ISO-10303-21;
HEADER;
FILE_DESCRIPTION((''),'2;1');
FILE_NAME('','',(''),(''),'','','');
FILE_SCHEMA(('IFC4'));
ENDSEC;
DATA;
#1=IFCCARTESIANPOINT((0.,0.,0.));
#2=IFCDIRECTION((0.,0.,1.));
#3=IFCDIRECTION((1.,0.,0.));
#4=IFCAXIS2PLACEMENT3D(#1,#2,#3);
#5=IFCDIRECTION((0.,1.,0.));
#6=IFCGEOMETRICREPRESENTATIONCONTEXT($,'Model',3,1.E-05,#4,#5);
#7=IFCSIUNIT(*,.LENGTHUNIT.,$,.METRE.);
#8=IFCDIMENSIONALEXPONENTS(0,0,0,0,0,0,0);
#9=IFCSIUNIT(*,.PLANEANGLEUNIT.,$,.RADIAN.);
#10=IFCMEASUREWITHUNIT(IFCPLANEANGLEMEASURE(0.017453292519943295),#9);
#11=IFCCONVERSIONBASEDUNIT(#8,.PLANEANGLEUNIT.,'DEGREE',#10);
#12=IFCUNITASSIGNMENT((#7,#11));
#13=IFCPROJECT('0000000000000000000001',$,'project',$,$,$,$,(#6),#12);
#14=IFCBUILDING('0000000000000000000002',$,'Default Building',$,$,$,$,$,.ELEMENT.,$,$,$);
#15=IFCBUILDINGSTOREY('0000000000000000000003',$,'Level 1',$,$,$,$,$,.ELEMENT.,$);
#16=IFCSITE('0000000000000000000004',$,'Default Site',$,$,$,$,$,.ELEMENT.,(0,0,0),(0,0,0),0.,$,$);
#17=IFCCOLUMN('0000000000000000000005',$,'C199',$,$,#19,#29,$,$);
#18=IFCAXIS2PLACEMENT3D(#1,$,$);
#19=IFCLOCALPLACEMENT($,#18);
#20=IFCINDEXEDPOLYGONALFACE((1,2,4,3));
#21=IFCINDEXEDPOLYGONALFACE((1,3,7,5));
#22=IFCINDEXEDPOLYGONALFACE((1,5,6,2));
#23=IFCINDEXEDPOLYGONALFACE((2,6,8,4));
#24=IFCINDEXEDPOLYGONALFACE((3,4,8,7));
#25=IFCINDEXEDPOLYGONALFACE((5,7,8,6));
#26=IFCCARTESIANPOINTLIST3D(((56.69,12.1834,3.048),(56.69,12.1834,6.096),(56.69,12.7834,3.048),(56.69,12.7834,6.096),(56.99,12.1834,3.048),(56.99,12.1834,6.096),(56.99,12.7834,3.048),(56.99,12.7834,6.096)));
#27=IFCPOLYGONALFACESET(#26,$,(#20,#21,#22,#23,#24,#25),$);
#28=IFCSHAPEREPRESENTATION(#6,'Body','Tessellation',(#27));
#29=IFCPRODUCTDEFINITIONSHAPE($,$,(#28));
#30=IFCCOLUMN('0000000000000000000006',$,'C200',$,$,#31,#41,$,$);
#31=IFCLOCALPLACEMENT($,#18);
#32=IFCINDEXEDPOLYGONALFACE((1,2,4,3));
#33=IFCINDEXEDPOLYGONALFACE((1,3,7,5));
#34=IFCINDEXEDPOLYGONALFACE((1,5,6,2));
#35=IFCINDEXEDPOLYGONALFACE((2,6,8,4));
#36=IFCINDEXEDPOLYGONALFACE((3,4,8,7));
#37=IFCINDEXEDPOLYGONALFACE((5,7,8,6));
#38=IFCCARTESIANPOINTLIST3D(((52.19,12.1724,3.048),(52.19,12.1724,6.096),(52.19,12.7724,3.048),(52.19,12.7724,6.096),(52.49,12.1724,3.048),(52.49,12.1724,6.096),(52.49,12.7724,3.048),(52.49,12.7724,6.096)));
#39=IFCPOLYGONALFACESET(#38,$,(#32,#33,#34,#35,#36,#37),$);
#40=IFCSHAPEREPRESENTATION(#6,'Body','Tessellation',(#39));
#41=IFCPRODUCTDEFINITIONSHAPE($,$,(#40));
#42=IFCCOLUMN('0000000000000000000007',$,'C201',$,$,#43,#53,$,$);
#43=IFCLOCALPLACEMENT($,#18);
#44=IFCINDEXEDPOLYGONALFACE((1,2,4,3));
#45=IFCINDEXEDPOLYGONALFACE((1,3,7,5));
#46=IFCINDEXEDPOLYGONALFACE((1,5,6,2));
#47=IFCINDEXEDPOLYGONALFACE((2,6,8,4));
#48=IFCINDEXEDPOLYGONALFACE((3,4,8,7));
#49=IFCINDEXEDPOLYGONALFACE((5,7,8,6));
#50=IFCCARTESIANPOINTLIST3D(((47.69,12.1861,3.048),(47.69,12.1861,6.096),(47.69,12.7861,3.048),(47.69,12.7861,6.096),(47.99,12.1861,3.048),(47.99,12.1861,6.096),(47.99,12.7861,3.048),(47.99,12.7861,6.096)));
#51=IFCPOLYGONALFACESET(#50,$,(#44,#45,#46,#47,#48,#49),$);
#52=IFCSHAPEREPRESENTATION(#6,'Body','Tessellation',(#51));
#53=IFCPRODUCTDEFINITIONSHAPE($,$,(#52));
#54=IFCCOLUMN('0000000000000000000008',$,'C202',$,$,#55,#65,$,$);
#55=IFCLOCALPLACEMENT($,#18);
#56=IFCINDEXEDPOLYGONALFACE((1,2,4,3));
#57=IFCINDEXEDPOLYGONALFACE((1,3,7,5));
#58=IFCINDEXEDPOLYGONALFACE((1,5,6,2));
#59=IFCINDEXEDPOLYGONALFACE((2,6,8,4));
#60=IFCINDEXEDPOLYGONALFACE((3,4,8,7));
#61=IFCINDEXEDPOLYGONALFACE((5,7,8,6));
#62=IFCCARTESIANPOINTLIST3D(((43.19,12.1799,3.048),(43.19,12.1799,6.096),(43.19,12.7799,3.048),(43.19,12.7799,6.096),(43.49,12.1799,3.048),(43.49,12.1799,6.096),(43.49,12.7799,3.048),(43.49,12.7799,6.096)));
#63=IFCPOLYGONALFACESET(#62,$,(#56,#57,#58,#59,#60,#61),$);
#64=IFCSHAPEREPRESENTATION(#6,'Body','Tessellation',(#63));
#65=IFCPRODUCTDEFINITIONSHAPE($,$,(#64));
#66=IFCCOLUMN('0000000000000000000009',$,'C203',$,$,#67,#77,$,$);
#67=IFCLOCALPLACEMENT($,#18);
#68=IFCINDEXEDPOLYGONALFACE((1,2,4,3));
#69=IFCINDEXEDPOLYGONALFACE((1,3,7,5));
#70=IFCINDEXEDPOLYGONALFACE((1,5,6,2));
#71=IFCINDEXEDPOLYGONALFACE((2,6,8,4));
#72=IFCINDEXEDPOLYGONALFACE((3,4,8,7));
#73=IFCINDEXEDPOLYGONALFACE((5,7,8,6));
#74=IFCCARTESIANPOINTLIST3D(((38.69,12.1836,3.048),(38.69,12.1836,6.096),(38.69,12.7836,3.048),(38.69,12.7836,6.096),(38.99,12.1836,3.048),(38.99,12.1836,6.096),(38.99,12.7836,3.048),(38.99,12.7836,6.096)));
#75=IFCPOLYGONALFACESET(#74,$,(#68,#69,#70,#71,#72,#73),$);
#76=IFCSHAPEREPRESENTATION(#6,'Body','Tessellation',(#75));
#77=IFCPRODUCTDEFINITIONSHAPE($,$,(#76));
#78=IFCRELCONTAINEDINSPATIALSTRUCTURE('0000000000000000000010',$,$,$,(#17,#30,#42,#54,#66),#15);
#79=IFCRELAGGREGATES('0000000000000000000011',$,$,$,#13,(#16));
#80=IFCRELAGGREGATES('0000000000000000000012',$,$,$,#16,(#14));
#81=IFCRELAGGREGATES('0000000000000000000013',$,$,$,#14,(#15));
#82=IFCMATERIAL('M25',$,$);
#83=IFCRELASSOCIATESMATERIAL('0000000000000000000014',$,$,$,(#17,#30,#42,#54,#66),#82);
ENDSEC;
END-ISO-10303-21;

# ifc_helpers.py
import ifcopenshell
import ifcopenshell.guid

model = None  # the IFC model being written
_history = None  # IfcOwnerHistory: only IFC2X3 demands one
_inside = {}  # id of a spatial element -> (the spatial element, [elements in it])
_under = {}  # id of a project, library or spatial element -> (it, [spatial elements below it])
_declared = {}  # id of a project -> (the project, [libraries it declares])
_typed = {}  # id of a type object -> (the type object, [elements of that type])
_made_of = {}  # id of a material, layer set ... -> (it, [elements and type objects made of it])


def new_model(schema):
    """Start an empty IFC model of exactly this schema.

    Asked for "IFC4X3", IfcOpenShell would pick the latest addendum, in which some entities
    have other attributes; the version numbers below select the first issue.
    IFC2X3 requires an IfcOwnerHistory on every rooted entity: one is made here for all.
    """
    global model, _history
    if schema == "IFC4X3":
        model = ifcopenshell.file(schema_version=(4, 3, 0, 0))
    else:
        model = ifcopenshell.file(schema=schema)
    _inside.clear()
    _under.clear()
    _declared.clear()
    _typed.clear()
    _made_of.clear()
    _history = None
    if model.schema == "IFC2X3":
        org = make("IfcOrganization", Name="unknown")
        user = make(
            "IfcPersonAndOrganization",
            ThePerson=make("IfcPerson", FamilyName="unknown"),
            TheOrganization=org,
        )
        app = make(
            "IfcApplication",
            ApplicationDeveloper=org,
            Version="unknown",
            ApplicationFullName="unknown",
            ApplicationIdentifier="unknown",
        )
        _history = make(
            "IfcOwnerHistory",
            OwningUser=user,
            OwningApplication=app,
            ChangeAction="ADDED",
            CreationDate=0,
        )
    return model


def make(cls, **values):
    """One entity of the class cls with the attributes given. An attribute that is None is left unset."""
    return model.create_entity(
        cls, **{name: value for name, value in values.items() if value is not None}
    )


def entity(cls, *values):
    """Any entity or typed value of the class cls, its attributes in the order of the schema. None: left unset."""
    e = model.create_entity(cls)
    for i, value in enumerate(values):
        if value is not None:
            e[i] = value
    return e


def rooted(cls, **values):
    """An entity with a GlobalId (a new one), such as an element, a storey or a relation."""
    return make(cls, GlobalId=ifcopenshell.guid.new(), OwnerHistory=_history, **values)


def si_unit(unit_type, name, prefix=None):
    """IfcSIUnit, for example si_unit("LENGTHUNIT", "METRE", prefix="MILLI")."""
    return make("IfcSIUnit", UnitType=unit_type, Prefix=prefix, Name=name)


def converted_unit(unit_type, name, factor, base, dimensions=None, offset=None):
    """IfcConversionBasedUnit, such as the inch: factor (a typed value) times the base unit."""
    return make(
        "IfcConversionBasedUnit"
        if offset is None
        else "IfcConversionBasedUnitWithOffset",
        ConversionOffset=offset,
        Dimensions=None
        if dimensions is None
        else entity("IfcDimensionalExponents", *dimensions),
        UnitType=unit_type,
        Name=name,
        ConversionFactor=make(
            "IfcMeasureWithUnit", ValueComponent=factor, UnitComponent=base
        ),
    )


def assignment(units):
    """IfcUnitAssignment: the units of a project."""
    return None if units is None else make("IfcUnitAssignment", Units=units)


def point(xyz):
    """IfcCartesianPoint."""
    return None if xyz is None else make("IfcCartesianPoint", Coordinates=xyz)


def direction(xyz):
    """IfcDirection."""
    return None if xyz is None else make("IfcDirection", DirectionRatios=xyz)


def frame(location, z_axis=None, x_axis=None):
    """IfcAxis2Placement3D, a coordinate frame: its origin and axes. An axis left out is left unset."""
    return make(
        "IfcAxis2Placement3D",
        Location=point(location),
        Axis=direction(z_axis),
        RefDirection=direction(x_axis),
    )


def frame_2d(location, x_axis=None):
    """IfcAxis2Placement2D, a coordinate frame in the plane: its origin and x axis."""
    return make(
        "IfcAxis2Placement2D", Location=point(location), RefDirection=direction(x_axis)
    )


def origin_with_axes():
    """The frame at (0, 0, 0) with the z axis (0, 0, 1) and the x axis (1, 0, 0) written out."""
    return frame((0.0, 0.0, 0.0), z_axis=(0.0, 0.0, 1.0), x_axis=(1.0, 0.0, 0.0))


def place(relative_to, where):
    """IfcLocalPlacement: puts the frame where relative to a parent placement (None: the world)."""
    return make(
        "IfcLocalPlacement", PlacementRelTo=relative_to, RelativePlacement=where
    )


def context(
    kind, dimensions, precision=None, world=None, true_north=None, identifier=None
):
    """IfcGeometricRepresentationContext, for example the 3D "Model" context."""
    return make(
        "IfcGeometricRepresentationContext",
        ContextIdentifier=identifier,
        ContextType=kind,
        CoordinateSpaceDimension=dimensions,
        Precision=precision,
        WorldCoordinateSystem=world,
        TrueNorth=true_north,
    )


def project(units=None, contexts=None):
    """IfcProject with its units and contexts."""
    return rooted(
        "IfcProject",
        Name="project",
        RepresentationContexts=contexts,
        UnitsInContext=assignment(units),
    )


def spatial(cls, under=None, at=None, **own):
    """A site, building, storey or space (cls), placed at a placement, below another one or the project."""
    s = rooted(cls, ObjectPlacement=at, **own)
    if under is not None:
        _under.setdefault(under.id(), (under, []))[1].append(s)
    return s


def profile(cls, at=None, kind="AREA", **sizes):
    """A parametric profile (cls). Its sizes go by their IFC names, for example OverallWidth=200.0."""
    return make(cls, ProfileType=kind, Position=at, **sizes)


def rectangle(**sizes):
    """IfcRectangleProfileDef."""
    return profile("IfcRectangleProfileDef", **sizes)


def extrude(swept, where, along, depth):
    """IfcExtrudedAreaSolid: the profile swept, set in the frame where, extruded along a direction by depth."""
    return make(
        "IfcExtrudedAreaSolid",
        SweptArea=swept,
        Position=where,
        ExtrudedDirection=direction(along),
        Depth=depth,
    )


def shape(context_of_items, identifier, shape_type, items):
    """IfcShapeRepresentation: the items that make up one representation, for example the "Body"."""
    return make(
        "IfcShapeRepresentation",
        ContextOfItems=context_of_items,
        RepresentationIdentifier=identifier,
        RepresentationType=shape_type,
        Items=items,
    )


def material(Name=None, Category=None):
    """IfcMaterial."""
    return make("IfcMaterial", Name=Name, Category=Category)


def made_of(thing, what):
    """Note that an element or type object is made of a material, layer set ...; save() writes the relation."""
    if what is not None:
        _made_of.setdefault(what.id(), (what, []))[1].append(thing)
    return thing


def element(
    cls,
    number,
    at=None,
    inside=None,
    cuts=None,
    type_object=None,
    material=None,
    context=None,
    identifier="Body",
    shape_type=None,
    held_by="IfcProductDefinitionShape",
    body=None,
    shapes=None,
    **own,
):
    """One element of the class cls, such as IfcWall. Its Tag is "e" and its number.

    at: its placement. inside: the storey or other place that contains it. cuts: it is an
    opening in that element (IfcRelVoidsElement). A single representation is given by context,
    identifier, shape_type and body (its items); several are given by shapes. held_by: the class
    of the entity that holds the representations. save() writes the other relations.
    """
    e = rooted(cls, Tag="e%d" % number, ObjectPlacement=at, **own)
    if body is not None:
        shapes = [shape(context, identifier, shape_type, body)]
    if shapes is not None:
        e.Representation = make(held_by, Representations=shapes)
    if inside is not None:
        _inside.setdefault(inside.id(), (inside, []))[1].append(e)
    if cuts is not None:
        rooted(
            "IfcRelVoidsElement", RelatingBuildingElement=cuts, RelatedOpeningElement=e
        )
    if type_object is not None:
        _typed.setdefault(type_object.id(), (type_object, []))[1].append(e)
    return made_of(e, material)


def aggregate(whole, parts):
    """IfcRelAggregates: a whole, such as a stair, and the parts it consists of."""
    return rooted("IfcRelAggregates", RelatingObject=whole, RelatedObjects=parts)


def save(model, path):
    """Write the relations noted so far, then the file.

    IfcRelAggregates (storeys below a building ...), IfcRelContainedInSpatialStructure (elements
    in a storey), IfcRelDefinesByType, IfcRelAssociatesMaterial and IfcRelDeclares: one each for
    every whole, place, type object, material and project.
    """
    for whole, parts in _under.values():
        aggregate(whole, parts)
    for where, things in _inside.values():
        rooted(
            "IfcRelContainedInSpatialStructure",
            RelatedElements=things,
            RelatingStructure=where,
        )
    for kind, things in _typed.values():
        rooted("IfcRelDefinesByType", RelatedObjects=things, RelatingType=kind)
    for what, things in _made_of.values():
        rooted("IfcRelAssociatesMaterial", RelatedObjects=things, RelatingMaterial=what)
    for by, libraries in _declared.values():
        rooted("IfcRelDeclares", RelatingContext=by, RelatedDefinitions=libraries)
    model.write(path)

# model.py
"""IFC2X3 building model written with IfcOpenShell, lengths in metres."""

from ifc_helpers import new_model, entity, si_unit, converted_unit, direction, frame, frame_2d, origin_with_axes, place, context, project, spatial, rectangle, extrude, material, element, save


model = new_model("IFC2X3")

# Units and contexts
model_context = context("Model", 3, precision=1e-05, world=origin_with_axes(), true_north=direction((0.0, 1.0, 0.0)))
ifc_project = project(units=[si_unit("LENGTHUNIT", "METRE"), converted_unit("PLANEANGLEUNIT", "DEGREE", entity("IfcPlaneAngleMeasure", 0.017453292519943295), si_unit("PLANEANGLEUNIT", "RADIAN"), dimensions=[0, 0, 0, 0, 0, 0, 0])], contexts=[model_context])

# Site, building, storey
site = spatial("IfcSite", under=ifc_project, Name="Default Site", CompositionType="ELEMENT", RefLatitude=(0, 0, 0), RefLongitude=(0, 0, 0), RefElevation=0.0)
building = spatial("IfcBuilding", under=site, Name="Default Building", CompositionType="ELEMENT")
storey = spatial("IfcBuildingStorey", under=building, Name="Level 1", CompositionType="ELEMENT")

# Columns
ifc_material = material(Name="M25")
placement = place(None, origin_with_axes())
element("IfcColumn", 1, at=placement, inside=storey, material=ifc_material, Name="C199", context=model_context, shape_type="SweptSolid", body=[
    extrude(rectangle(XDim=0.3, YDim=0.6, at=frame_2d((0.0, 0.0), x_axis=(1.0, 0.0, 0.0))), frame((56.84, 12.4834, 3.048), z_axis=(0.0, 0.0, 1.0), x_axis=(1.0, 0.0, 0.0)), (0.0, 0.0, 1.0), 3.048),
])
element("IfcColumn", 2, at=placement, inside=storey, material=ifc_material, Name="C200", context=model_context, shape_type="SweptSolid", body=[
    extrude(rectangle(XDim=0.3, YDim=0.6, at=frame_2d((0.0, 0.0), x_axis=(1.0, 0.0, 0.0))), frame((52.34, 12.4724, 3.048), z_axis=(0.0, 0.0, 1.0), x_axis=(1.0, 0.0, 0.0)), (0.0, 0.0, 1.0), 3.048),
])
element("IfcColumn", 3, at=placement, inside=storey, material=ifc_material, Name="C201", context=model_context, shape_type="SweptSolid", body=[
    extrude(rectangle(XDim=0.3, YDim=0.6, at=frame_2d((0.0, 0.0), x_axis=(1.0, 0.0, 0.0))), frame((47.84, 12.4861, 3.048), z_axis=(0.0, 0.0, 1.0), x_axis=(1.0, 0.0, 0.0)), (0.0, 0.0, 1.0), 3.048),
])
element("IfcColumn", 4, at=placement, inside=storey, material=ifc_material, Name="C202", context=model_context, shape_type="SweptSolid", body=[
    extrude(rectangle(XDim=0.3, YDim=0.6, at=frame_2d((0.0, 0.0), x_axis=(1.0, 0.0, 0.0))), frame((43.34, 12.4799, 3.048), z_axis=(0.0, 0.0, 1.0), x_axis=(1.0, 0.0, 0.0)), (0.0, 0.0, 1.0), 3.048),
])
element("IfcColumn", 5, at=placement, inside=storey, material=ifc_material, Name="C203", context=model_context, shape_type="SweptSolid", body=[
    extrude(rectangle(XDim=0.3, YDim=0.6, at=frame_2d((0.0, 0.0), x_axis=(1.0, 0.0, 0.0))), frame((38.84, 12.4836, 3.048), z_axis=(0.0, 0.0, 1.0), x_axis=(1.0, 0.0, 0.0)), (0.0, 0.0, 1.0), 3.048),
])

save(model, "model.ifc")
